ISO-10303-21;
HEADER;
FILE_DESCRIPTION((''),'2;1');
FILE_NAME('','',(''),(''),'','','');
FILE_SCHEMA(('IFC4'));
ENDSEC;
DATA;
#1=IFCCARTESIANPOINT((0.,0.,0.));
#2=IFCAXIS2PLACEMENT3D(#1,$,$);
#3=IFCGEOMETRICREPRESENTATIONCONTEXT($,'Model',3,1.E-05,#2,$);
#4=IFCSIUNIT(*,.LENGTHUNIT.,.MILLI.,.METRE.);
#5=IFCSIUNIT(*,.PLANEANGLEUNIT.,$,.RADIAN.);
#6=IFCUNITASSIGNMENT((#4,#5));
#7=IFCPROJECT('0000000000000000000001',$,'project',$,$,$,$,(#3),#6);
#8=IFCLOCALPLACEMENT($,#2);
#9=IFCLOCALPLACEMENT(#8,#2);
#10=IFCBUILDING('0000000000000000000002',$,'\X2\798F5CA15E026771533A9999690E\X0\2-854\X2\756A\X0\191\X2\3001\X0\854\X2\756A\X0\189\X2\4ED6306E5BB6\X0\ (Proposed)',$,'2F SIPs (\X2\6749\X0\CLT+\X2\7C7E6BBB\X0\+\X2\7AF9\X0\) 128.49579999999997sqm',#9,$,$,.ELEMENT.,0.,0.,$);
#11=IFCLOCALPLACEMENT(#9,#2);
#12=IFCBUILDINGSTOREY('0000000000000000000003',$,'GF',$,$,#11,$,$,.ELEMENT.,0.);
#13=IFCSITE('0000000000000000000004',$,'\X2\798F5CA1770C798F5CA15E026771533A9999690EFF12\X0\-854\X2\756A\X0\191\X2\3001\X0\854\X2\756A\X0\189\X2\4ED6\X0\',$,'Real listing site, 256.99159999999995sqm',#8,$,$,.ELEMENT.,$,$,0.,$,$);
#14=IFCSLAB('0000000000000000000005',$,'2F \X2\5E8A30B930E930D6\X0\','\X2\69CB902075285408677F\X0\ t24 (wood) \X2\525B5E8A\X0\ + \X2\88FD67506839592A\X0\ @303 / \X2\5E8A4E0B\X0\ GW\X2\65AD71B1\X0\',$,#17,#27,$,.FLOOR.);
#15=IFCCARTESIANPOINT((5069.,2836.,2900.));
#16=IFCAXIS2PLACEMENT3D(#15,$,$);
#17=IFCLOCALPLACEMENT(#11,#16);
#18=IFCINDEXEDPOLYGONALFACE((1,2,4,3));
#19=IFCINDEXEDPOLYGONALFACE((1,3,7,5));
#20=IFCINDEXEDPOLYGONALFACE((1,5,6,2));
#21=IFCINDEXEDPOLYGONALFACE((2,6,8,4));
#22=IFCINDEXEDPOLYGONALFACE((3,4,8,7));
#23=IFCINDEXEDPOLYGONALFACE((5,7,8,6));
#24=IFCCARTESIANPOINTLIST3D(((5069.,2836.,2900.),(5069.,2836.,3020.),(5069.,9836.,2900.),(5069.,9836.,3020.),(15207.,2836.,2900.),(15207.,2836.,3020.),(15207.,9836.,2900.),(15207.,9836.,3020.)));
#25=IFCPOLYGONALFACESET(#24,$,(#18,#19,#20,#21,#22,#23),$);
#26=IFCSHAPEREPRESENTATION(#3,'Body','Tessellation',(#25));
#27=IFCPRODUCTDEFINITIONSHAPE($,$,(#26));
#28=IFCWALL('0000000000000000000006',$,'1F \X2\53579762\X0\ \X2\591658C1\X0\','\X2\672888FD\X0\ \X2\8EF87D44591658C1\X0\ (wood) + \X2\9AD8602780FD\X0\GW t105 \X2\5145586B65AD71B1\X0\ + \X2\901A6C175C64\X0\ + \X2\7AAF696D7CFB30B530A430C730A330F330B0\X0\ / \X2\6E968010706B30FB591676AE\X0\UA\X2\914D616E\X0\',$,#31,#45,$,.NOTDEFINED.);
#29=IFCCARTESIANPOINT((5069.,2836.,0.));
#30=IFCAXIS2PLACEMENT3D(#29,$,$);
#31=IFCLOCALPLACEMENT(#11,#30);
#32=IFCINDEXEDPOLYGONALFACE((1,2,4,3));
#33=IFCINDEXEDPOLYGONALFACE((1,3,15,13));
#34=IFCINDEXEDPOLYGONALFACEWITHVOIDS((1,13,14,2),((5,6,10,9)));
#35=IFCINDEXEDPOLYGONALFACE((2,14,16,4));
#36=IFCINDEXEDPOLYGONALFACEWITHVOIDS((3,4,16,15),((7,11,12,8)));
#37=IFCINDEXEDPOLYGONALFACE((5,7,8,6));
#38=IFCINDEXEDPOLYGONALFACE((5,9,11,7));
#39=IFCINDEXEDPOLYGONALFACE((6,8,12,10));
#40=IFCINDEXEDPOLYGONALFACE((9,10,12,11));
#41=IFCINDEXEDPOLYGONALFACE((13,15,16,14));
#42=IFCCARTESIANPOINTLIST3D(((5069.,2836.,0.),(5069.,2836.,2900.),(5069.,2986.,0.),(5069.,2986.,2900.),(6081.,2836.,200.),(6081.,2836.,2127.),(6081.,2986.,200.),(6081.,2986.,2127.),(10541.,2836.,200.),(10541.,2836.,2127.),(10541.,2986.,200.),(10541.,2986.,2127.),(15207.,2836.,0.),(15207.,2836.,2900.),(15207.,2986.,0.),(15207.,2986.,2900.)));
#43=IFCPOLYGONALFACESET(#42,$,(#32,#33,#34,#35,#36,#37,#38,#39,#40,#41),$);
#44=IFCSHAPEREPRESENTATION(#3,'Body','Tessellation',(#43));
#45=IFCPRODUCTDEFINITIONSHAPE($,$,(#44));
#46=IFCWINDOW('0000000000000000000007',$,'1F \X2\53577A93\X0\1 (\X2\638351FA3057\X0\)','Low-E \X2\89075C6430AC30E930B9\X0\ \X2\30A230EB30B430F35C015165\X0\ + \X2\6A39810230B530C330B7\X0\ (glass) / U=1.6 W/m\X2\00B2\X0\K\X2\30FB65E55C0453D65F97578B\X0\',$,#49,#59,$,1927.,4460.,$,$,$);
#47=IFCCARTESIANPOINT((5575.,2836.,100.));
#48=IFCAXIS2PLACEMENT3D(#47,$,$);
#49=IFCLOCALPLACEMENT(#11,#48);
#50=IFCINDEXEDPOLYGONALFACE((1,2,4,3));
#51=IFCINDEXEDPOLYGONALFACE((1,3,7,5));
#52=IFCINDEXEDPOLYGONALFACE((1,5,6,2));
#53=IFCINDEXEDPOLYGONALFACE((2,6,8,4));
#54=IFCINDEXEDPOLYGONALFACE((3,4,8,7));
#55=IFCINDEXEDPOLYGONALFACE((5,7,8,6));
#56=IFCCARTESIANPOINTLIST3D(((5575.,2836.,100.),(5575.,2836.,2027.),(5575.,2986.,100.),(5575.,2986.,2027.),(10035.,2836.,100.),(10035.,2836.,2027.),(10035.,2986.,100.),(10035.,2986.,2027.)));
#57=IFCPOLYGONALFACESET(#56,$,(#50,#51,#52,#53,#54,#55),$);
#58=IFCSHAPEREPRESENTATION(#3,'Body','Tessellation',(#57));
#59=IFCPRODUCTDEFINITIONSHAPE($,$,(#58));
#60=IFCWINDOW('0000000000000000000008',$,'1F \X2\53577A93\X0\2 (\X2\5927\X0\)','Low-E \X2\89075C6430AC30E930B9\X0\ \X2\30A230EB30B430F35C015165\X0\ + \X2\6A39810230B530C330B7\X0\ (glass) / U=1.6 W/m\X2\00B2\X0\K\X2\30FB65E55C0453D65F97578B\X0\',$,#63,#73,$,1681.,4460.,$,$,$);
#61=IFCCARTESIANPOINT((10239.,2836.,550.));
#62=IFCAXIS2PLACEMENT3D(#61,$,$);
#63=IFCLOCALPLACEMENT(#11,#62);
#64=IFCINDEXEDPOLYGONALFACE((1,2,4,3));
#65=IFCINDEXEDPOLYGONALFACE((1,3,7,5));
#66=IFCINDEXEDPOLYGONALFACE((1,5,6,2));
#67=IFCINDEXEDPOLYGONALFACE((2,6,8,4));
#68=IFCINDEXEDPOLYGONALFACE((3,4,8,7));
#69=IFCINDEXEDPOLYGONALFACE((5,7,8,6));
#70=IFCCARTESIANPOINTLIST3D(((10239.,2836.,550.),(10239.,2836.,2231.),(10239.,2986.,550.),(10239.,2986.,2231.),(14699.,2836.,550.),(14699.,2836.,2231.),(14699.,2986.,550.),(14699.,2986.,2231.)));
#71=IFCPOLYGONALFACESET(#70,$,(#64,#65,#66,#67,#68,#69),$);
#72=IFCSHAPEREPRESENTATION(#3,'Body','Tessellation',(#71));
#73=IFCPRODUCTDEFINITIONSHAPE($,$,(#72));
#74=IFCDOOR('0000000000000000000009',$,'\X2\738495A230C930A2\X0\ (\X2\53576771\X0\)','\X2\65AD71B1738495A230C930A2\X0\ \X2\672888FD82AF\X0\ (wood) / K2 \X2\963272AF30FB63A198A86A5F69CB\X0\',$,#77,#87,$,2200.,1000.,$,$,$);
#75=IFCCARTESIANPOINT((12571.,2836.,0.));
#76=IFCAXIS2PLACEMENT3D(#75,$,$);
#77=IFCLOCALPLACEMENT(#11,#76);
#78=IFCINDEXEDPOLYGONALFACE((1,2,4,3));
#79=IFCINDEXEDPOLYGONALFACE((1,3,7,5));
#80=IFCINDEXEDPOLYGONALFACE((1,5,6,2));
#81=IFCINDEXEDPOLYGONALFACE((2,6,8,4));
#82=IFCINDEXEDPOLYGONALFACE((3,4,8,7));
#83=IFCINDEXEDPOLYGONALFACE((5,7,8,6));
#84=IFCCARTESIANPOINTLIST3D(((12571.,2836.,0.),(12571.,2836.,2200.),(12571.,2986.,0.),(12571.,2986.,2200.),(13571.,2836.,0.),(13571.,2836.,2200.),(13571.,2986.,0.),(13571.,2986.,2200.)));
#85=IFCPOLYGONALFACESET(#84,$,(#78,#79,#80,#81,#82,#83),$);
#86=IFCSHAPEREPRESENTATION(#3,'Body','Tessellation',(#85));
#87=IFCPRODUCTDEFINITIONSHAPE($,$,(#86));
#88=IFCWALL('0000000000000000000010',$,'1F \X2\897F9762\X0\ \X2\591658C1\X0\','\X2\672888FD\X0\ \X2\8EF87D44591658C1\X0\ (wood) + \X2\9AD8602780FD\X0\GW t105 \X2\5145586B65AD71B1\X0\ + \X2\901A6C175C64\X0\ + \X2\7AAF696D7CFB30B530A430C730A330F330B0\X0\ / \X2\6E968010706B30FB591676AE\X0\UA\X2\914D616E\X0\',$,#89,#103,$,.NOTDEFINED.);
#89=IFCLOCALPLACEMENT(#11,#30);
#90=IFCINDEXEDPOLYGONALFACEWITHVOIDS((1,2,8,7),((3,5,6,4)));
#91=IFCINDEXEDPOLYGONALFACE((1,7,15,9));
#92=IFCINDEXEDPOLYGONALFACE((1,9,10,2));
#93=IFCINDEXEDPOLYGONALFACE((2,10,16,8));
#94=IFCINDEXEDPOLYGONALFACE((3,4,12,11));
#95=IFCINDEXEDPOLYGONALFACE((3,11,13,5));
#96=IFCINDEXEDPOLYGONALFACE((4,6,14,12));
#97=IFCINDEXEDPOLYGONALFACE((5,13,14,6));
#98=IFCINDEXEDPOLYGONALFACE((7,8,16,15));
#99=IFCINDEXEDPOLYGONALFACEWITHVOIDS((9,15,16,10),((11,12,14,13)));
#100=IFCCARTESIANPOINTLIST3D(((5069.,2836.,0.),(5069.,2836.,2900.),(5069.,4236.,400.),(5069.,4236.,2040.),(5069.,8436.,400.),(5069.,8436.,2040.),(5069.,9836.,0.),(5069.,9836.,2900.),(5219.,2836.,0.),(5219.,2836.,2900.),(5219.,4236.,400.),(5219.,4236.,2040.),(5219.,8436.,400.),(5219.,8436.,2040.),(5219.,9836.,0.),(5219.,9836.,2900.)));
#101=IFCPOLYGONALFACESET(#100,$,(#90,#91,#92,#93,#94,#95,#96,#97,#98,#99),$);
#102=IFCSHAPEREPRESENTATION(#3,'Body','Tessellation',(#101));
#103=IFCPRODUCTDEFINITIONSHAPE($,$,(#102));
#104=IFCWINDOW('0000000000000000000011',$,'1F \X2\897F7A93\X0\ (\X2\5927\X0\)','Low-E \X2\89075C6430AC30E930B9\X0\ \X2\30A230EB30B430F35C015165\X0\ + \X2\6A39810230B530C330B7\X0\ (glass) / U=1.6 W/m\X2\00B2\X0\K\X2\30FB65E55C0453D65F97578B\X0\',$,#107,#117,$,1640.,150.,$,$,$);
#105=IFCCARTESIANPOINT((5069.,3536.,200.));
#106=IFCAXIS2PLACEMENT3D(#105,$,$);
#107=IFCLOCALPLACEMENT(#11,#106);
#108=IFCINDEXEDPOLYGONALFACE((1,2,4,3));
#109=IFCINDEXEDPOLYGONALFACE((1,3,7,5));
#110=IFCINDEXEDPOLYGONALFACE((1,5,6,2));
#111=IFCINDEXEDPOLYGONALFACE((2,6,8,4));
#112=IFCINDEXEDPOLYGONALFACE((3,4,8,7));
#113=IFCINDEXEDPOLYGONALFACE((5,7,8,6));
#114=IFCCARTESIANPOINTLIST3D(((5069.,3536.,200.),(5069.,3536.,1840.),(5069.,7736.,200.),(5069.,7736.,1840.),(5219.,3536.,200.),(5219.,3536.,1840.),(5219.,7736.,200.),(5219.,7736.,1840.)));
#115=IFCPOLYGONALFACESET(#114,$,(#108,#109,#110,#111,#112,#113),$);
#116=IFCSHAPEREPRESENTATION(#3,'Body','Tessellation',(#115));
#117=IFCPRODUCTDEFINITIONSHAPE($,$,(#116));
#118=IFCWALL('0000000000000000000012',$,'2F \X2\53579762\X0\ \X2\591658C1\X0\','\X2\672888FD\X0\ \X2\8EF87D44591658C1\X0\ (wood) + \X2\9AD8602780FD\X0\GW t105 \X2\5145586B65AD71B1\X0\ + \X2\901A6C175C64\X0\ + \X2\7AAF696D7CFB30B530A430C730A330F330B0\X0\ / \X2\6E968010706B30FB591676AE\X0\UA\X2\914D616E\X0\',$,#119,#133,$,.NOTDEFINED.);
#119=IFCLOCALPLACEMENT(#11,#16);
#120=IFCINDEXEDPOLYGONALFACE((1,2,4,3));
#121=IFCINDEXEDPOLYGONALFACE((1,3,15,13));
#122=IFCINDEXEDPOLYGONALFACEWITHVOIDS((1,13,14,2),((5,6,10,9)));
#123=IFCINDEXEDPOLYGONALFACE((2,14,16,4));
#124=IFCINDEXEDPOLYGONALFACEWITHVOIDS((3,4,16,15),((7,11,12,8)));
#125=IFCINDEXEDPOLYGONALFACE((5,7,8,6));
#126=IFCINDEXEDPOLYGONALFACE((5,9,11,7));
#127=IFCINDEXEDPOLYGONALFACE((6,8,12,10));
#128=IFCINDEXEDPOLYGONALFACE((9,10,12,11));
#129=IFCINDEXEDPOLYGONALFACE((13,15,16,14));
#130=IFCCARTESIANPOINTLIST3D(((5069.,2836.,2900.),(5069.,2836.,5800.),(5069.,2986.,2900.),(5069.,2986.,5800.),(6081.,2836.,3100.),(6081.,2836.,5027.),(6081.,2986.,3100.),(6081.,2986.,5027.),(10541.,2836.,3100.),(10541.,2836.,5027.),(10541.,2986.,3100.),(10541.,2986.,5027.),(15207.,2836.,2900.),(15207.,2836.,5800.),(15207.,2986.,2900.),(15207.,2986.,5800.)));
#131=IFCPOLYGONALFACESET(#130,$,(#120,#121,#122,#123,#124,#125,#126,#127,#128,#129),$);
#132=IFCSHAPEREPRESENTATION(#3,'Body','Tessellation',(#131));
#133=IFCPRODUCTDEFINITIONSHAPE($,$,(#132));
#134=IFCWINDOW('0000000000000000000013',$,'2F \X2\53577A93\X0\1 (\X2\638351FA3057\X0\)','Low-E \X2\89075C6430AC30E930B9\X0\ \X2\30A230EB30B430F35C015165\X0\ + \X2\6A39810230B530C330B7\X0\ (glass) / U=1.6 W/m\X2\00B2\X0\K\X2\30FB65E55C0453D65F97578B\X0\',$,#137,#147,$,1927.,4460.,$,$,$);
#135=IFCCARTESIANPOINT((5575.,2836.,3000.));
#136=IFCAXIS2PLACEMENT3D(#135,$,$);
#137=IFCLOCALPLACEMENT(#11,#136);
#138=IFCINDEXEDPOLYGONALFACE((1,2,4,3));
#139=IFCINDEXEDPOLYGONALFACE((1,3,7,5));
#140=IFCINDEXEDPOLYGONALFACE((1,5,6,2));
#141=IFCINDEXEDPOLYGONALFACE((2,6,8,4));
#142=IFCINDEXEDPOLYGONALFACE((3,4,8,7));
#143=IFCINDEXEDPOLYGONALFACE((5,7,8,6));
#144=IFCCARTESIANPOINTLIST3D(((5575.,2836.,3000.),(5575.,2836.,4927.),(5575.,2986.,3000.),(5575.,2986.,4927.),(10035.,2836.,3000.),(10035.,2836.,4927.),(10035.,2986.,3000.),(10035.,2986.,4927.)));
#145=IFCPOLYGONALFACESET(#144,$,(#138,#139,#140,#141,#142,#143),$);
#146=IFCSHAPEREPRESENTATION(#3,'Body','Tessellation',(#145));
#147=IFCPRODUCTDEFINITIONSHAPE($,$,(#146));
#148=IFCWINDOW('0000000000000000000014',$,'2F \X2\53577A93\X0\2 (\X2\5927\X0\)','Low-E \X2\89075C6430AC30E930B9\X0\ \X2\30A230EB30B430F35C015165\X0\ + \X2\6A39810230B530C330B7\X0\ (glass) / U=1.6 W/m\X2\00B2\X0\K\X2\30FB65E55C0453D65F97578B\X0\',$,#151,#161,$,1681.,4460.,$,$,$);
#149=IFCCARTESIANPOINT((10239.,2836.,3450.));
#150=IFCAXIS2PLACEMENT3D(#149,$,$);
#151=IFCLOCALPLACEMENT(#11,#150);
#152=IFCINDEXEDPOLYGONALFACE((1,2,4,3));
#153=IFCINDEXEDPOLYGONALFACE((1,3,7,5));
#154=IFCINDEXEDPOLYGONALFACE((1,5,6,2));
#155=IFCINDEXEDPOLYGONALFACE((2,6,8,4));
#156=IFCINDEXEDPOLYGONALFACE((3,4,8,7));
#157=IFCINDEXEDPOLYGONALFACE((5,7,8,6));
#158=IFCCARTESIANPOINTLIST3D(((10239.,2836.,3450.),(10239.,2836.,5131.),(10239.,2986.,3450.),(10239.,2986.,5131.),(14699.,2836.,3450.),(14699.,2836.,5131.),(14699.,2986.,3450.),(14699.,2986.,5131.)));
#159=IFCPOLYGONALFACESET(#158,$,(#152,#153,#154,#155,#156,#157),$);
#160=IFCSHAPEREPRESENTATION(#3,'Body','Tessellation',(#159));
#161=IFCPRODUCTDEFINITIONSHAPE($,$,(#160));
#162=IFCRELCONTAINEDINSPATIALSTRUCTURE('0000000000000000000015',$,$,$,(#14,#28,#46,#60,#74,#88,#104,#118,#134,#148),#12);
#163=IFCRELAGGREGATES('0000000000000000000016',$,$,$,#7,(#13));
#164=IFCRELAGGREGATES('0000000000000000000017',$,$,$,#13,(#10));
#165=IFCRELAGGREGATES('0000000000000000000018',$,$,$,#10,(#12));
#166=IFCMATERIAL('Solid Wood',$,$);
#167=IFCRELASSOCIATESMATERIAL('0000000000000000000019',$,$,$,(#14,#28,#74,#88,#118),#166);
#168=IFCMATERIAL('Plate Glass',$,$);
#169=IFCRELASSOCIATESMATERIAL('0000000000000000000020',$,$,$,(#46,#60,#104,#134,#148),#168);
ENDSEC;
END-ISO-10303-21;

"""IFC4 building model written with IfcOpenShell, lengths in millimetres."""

from ifc_helpers import new_model, si_unit, frame, frame_2d, origin, place, context, project, spatial, rectangle, extrude, material, element, fill, save


model = new_model("IFC4")

# Units and contexts
model_context = context("Model", 3, precision=1e-05, world=origin())
ifc_project = project(units=[si_unit("LENGTHUNIT", "METRE", prefix="MILLI"), si_unit("PLANEANGLEUNIT", "RADIAN")], contexts=[model_context])

# Site, building, storey
site_placement = place(None, origin())
site = spatial("IfcSite", under=ifc_project, at=site_placement, Name="福岡県福岡市東区香椎２-854番191、854番189他", ObjectType="Real listing site, 256.99159999999995sqm", CompositionType="ELEMENT", RefElevation=0.0)
building_placement = place(site_placement, origin())
building = spatial("IfcBuilding", under=site, at=building_placement, Name="福岡市東区香椎2-854番191、854番189他の家 (Proposed)", ObjectType="2F SIPs (杉CLT+籾殻+竹) 128.49579999999997sqm", CompositionType="ELEMENT", ElevationOfRefHeight=0.0, ElevationOfTerrain=0.0)
storey_placement = place(building_placement, origin())
storey = spatial("IfcBuildingStorey", under=building, at=storey_placement, Name="GF", CompositionType="ELEMENT", Elevation=0.0)

# Slab
ifc_material_1 = material(Name="Solid Wood")
slab_1_placement = place(storey_placement, frame((5069.0, 2836.0, 2900.0)))
element("IfcSlab", 1, at=slab_1_placement, inside=storey, material=ifc_material_1, Name="2F 床スラブ", Description="構造用合板 t24 (wood) 剛床 + 製材根太 @303 / 床下 GW断熱", PredefinedType="FLOOR", context=model_context, shape_type="SweptSolid", body=[
    extrude(rectangle(XDim=10138.0, YDim=7000.0, at=frame_2d((5069.0, 3500.0))), frame((5069.0, 2836.0, 2900.0)), (0.0, 0.0, 1.0), 120.0),
])

# Wall, openings, windows, door
wall_1_placement = place(storey_placement, frame((5069.0, 2836.0, 0.0)))
wall_1 = element("IfcWall", 2, at=wall_1_placement, inside=storey, material=ifc_material_1, Name="1F 南面 外壁", Description="木製 軸組外壁 (wood) + 高性能GW t105 充填断熱 + 通気層 + 窯業系サイディング / 準耐火・外皮UA配慮", PredefinedType="NOTDEFINED", context=model_context, shape_type="SweptSolid", body=[
    extrude(rectangle(XDim=10138.0, YDim=150.0, at=frame_2d((5069.0, 75.0))), frame((5069.0, 2836.0, 0.0)), (0.0, 0.0, 1.0), 2900.0),
])
opening_1_placement = place(storey_placement, frame((5575.0, 2836.0, 100.0)))
opening_1 = element("IfcOpeningElement", 3, at=opening_1_placement, cuts=wall_1, PredefinedType="NOTDEFINED", context=model_context, shape_type="SweptSolid", body=[
    extrude(rectangle(XDim=4460.0, YDim=150.0, at=frame_2d((2230.0, 75.0))), frame((5575.0, 2836.0, 100.0)), (0.0, 0.0, 1.0), 1927.0),
])
opening_2_placement = place(storey_placement, frame((10239.0, 2836.0, 550.0)))
opening_2 = element("IfcOpeningElement", 4, at=opening_2_placement, cuts=wall_1, PredefinedType="NOTDEFINED", context=model_context, shape_type="SweptSolid", body=[
    extrude(rectangle(XDim=4460.0, YDim=150.0, at=frame_2d((2230.0, 75.0))), frame((10239.0, 2836.0, 550.0)), (0.0, 0.0, 1.0), 1681.0),
])
opening_3_placement = place(storey_placement, frame((12571.0, 2836.0, 0.0)))
opening_3 = element("IfcOpeningElement", 5, at=opening_3_placement, cuts=wall_1, PredefinedType="NOTDEFINED", context=model_context, shape_type="SweptSolid", body=[
    extrude(rectangle(XDim=1000.0, YDim=150.0, at=frame_2d((500.0, 75.0))), frame((12571.0, 2836.0, 0.0)), (0.0, 0.0, 1.0), 2200.0),
])
ifc_material_2 = material(Name="Plate Glass")
window_1_placement = place(storey_placement, frame((5575.0, 2836.0, 100.0)))
window_1 = element("IfcWindow", 6, at=window_1_placement, inside=storey, material=ifc_material_2, Name="1F 南窓1 (掃出し)", Description="Low-E 複層ガラス アルゴン封入 + 樹脂サッシ (glass) / U=1.6 W/m²K・日射取得型", OverallHeight=1927.0, OverallWidth=4460.0, context=model_context, shape_type="SweptSolid", body=[
    extrude(rectangle(XDim=4460.0, YDim=150.0, at=frame_2d((2230.0, 75.0))), frame((5575.0, 2836.0, 100.0)), (0.0, 0.0, 1.0), 1927.0),
])
fill(opening_1, window_1)
window_2_placement = place(storey_placement, frame((10239.0, 2836.0, 550.0)))
window_2 = element("IfcWindow", 7, at=window_2_placement, inside=storey, material=ifc_material_2, Name="1F 南窓2 (大)", Description="Low-E 複層ガラス アルゴン封入 + 樹脂サッシ (glass) / U=1.6 W/m²K・日射取得型", OverallHeight=1681.0, OverallWidth=4460.0, context=model_context, shape_type="SweptSolid", body=[
    extrude(rectangle(XDim=4460.0, YDim=150.0, at=frame_2d((2230.0, 75.0))), frame((10239.0, 2836.0, 550.0)), (0.0, 0.0, 1.0), 1681.0),
])
fill(opening_2, window_2)
door_placement = place(storey_placement, frame((12571.0, 2836.0, 0.0)))
door = element("IfcDoor", 8, at=door_placement, inside=storey, material=ifc_material_1, Name="玄関ドア (南東)", Description="断熱玄関ドア 木製芯 (wood) / K2 防犯・採風機構", OverallHeight=2200.0, OverallWidth=1000.0, context=model_context, shape_type="SweptSolid", body=[
    extrude(rectangle(XDim=1000.0, YDim=150.0, at=frame_2d((500.0, 75.0))), frame((12571.0, 2836.0, 0.0)), (0.0, 0.0, 1.0), 2200.0),
])
fill(opening_3, door)

# Wall, opening, window
wall_2_placement = place(storey_placement, frame((5069.0, 2836.0, 0.0)))
wall_2 = element("IfcWall", 9, at=wall_2_placement, inside=storey, material=ifc_material_1, Name="1F 西面 外壁", Description="木製 軸組外壁 (wood) + 高性能GW t105 充填断熱 + 通気層 + 窯業系サイディング / 準耐火・外皮UA配慮", PredefinedType="NOTDEFINED", context=model_context, shape_type="SweptSolid", body=[
    extrude(rectangle(XDim=150.0, YDim=7000.0, at=frame_2d((75.0, 3500.0))), frame((5069.0, 2836.0, 0.0)), (0.0, 0.0, 1.0), 2900.0),
])
opening_4_placement = place(storey_placement, frame((5069.0, 3536.0, 200.0)))
opening_4 = element("IfcOpeningElement", 10, at=opening_4_placement, cuts=wall_2, PredefinedType="NOTDEFINED", context=model_context, shape_type="SweptSolid", body=[
    extrude(rectangle(XDim=150.0, YDim=4200.0, at=frame_2d((75.0, 2100.0))), frame((5069.0, 3536.0, 200.0)), (0.0, 0.0, 1.0), 1640.0),
])
window_3_placement = place(storey_placement, frame((5069.0, 3536.0, 200.0)))
window_3 = element("IfcWindow", 11, at=window_3_placement, inside=storey, material=ifc_material_2, Name="1F 西窓 (大)", Description="Low-E 複層ガラス アルゴン封入 + 樹脂サッシ (glass) / U=1.6 W/m²K・日射取得型", OverallHeight=1640.0, OverallWidth=150.0, context=model_context, shape_type="SweptSolid", body=[
    extrude(rectangle(XDim=150.0, YDim=4200.0, at=frame_2d((75.0, 2100.0))), frame((5069.0, 3536.0, 200.0)), (0.0, 0.0, 1.0), 1640.0),
])
fill(opening_4, window_3)

# Wall, openings, windows
wall_3_placement = place(storey_placement, frame((5069.0, 2836.0, 2900.0)))
wall_3 = element("IfcWall", 12, at=wall_3_placement, inside=storey, material=ifc_material_1, Name="2F 南面 外壁", Description="木製 軸組外壁 (wood) + 高性能GW t105 充填断熱 + 通気層 + 窯業系サイディング / 準耐火・外皮UA配慮", PredefinedType="NOTDEFINED", context=model_context, shape_type="SweptSolid", body=[
    extrude(rectangle(XDim=10138.0, YDim=150.0, at=frame_2d((5069.0, 75.0))), frame((5069.0, 2836.0, 2900.0)), (0.0, 0.0, 1.0), 2900.0),
])
opening_5_placement = place(storey_placement, frame((5575.0, 2836.0, 3000.0)))
opening_5 = element("IfcOpeningElement", 13, at=opening_5_placement, cuts=wall_3, PredefinedType="NOTDEFINED", context=model_context, shape_type="SweptSolid", body=[
    extrude(rectangle(XDim=4460.0, YDim=150.0, at=frame_2d((2230.0, 75.0))), frame((5575.0, 2836.0, 3000.0)), (0.0, 0.0, 1.0), 1927.0),
])
opening_6_placement = place(storey_placement, frame((10239.0, 2836.0, 3450.0)))
opening_6 = element("IfcOpeningElement", 14, at=opening_6_placement, cuts=wall_3, PredefinedType="NOTDEFINED", context=model_context, shape_type="SweptSolid", body=[
    extrude(rectangle(XDim=4460.0, YDim=150.0, at=frame_2d((2230.0, 75.0))), frame((10239.0, 2836.0, 3450.0)), (0.0, 0.0, 1.0), 1681.0),
])
window_4_placement = place(storey_placement, frame((5575.0, 2836.0, 3000.0)))
window_4 = element("IfcWindow", 15, at=window_4_placement, inside=storey, material=ifc_material_2, Name="2F 南窓1 (掃出し)", Description="Low-E 複層ガラス アルゴン封入 + 樹脂サッシ (glass) / U=1.6 W/m²K・日射取得型", OverallHeight=1927.0, OverallWidth=4460.0, context=model_context, shape_type="SweptSolid", body=[
    extrude(rectangle(XDim=4460.0, YDim=150.0, at=frame_2d((2230.0, 75.0))), frame((5575.0, 2836.0, 3000.0)), (0.0, 0.0, 1.0), 1927.0),
])
fill(opening_5, window_4)
window_5_placement = place(storey_placement, frame((10239.0, 2836.0, 3450.0)))
window_5 = element("IfcWindow", 16, at=window_5_placement, inside=storey, material=ifc_material_2, Name="2F 南窓2 (大)", Description="Low-E 複層ガラス アルゴン封入 + 樹脂サッシ (glass) / U=1.6 W/m²K・日射取得型", OverallHeight=1681.0, OverallWidth=4460.0, context=model_context, shape_type="SweptSolid", body=[
    extrude(rectangle(XDim=4460.0, YDim=150.0, at=frame_2d((2230.0, 75.0))), frame((10239.0, 2836.0, 3450.0)), (0.0, 0.0, 1.0), 1681.0),
])
fill(opening_6, window_5)

save(model, "model.ifc")
